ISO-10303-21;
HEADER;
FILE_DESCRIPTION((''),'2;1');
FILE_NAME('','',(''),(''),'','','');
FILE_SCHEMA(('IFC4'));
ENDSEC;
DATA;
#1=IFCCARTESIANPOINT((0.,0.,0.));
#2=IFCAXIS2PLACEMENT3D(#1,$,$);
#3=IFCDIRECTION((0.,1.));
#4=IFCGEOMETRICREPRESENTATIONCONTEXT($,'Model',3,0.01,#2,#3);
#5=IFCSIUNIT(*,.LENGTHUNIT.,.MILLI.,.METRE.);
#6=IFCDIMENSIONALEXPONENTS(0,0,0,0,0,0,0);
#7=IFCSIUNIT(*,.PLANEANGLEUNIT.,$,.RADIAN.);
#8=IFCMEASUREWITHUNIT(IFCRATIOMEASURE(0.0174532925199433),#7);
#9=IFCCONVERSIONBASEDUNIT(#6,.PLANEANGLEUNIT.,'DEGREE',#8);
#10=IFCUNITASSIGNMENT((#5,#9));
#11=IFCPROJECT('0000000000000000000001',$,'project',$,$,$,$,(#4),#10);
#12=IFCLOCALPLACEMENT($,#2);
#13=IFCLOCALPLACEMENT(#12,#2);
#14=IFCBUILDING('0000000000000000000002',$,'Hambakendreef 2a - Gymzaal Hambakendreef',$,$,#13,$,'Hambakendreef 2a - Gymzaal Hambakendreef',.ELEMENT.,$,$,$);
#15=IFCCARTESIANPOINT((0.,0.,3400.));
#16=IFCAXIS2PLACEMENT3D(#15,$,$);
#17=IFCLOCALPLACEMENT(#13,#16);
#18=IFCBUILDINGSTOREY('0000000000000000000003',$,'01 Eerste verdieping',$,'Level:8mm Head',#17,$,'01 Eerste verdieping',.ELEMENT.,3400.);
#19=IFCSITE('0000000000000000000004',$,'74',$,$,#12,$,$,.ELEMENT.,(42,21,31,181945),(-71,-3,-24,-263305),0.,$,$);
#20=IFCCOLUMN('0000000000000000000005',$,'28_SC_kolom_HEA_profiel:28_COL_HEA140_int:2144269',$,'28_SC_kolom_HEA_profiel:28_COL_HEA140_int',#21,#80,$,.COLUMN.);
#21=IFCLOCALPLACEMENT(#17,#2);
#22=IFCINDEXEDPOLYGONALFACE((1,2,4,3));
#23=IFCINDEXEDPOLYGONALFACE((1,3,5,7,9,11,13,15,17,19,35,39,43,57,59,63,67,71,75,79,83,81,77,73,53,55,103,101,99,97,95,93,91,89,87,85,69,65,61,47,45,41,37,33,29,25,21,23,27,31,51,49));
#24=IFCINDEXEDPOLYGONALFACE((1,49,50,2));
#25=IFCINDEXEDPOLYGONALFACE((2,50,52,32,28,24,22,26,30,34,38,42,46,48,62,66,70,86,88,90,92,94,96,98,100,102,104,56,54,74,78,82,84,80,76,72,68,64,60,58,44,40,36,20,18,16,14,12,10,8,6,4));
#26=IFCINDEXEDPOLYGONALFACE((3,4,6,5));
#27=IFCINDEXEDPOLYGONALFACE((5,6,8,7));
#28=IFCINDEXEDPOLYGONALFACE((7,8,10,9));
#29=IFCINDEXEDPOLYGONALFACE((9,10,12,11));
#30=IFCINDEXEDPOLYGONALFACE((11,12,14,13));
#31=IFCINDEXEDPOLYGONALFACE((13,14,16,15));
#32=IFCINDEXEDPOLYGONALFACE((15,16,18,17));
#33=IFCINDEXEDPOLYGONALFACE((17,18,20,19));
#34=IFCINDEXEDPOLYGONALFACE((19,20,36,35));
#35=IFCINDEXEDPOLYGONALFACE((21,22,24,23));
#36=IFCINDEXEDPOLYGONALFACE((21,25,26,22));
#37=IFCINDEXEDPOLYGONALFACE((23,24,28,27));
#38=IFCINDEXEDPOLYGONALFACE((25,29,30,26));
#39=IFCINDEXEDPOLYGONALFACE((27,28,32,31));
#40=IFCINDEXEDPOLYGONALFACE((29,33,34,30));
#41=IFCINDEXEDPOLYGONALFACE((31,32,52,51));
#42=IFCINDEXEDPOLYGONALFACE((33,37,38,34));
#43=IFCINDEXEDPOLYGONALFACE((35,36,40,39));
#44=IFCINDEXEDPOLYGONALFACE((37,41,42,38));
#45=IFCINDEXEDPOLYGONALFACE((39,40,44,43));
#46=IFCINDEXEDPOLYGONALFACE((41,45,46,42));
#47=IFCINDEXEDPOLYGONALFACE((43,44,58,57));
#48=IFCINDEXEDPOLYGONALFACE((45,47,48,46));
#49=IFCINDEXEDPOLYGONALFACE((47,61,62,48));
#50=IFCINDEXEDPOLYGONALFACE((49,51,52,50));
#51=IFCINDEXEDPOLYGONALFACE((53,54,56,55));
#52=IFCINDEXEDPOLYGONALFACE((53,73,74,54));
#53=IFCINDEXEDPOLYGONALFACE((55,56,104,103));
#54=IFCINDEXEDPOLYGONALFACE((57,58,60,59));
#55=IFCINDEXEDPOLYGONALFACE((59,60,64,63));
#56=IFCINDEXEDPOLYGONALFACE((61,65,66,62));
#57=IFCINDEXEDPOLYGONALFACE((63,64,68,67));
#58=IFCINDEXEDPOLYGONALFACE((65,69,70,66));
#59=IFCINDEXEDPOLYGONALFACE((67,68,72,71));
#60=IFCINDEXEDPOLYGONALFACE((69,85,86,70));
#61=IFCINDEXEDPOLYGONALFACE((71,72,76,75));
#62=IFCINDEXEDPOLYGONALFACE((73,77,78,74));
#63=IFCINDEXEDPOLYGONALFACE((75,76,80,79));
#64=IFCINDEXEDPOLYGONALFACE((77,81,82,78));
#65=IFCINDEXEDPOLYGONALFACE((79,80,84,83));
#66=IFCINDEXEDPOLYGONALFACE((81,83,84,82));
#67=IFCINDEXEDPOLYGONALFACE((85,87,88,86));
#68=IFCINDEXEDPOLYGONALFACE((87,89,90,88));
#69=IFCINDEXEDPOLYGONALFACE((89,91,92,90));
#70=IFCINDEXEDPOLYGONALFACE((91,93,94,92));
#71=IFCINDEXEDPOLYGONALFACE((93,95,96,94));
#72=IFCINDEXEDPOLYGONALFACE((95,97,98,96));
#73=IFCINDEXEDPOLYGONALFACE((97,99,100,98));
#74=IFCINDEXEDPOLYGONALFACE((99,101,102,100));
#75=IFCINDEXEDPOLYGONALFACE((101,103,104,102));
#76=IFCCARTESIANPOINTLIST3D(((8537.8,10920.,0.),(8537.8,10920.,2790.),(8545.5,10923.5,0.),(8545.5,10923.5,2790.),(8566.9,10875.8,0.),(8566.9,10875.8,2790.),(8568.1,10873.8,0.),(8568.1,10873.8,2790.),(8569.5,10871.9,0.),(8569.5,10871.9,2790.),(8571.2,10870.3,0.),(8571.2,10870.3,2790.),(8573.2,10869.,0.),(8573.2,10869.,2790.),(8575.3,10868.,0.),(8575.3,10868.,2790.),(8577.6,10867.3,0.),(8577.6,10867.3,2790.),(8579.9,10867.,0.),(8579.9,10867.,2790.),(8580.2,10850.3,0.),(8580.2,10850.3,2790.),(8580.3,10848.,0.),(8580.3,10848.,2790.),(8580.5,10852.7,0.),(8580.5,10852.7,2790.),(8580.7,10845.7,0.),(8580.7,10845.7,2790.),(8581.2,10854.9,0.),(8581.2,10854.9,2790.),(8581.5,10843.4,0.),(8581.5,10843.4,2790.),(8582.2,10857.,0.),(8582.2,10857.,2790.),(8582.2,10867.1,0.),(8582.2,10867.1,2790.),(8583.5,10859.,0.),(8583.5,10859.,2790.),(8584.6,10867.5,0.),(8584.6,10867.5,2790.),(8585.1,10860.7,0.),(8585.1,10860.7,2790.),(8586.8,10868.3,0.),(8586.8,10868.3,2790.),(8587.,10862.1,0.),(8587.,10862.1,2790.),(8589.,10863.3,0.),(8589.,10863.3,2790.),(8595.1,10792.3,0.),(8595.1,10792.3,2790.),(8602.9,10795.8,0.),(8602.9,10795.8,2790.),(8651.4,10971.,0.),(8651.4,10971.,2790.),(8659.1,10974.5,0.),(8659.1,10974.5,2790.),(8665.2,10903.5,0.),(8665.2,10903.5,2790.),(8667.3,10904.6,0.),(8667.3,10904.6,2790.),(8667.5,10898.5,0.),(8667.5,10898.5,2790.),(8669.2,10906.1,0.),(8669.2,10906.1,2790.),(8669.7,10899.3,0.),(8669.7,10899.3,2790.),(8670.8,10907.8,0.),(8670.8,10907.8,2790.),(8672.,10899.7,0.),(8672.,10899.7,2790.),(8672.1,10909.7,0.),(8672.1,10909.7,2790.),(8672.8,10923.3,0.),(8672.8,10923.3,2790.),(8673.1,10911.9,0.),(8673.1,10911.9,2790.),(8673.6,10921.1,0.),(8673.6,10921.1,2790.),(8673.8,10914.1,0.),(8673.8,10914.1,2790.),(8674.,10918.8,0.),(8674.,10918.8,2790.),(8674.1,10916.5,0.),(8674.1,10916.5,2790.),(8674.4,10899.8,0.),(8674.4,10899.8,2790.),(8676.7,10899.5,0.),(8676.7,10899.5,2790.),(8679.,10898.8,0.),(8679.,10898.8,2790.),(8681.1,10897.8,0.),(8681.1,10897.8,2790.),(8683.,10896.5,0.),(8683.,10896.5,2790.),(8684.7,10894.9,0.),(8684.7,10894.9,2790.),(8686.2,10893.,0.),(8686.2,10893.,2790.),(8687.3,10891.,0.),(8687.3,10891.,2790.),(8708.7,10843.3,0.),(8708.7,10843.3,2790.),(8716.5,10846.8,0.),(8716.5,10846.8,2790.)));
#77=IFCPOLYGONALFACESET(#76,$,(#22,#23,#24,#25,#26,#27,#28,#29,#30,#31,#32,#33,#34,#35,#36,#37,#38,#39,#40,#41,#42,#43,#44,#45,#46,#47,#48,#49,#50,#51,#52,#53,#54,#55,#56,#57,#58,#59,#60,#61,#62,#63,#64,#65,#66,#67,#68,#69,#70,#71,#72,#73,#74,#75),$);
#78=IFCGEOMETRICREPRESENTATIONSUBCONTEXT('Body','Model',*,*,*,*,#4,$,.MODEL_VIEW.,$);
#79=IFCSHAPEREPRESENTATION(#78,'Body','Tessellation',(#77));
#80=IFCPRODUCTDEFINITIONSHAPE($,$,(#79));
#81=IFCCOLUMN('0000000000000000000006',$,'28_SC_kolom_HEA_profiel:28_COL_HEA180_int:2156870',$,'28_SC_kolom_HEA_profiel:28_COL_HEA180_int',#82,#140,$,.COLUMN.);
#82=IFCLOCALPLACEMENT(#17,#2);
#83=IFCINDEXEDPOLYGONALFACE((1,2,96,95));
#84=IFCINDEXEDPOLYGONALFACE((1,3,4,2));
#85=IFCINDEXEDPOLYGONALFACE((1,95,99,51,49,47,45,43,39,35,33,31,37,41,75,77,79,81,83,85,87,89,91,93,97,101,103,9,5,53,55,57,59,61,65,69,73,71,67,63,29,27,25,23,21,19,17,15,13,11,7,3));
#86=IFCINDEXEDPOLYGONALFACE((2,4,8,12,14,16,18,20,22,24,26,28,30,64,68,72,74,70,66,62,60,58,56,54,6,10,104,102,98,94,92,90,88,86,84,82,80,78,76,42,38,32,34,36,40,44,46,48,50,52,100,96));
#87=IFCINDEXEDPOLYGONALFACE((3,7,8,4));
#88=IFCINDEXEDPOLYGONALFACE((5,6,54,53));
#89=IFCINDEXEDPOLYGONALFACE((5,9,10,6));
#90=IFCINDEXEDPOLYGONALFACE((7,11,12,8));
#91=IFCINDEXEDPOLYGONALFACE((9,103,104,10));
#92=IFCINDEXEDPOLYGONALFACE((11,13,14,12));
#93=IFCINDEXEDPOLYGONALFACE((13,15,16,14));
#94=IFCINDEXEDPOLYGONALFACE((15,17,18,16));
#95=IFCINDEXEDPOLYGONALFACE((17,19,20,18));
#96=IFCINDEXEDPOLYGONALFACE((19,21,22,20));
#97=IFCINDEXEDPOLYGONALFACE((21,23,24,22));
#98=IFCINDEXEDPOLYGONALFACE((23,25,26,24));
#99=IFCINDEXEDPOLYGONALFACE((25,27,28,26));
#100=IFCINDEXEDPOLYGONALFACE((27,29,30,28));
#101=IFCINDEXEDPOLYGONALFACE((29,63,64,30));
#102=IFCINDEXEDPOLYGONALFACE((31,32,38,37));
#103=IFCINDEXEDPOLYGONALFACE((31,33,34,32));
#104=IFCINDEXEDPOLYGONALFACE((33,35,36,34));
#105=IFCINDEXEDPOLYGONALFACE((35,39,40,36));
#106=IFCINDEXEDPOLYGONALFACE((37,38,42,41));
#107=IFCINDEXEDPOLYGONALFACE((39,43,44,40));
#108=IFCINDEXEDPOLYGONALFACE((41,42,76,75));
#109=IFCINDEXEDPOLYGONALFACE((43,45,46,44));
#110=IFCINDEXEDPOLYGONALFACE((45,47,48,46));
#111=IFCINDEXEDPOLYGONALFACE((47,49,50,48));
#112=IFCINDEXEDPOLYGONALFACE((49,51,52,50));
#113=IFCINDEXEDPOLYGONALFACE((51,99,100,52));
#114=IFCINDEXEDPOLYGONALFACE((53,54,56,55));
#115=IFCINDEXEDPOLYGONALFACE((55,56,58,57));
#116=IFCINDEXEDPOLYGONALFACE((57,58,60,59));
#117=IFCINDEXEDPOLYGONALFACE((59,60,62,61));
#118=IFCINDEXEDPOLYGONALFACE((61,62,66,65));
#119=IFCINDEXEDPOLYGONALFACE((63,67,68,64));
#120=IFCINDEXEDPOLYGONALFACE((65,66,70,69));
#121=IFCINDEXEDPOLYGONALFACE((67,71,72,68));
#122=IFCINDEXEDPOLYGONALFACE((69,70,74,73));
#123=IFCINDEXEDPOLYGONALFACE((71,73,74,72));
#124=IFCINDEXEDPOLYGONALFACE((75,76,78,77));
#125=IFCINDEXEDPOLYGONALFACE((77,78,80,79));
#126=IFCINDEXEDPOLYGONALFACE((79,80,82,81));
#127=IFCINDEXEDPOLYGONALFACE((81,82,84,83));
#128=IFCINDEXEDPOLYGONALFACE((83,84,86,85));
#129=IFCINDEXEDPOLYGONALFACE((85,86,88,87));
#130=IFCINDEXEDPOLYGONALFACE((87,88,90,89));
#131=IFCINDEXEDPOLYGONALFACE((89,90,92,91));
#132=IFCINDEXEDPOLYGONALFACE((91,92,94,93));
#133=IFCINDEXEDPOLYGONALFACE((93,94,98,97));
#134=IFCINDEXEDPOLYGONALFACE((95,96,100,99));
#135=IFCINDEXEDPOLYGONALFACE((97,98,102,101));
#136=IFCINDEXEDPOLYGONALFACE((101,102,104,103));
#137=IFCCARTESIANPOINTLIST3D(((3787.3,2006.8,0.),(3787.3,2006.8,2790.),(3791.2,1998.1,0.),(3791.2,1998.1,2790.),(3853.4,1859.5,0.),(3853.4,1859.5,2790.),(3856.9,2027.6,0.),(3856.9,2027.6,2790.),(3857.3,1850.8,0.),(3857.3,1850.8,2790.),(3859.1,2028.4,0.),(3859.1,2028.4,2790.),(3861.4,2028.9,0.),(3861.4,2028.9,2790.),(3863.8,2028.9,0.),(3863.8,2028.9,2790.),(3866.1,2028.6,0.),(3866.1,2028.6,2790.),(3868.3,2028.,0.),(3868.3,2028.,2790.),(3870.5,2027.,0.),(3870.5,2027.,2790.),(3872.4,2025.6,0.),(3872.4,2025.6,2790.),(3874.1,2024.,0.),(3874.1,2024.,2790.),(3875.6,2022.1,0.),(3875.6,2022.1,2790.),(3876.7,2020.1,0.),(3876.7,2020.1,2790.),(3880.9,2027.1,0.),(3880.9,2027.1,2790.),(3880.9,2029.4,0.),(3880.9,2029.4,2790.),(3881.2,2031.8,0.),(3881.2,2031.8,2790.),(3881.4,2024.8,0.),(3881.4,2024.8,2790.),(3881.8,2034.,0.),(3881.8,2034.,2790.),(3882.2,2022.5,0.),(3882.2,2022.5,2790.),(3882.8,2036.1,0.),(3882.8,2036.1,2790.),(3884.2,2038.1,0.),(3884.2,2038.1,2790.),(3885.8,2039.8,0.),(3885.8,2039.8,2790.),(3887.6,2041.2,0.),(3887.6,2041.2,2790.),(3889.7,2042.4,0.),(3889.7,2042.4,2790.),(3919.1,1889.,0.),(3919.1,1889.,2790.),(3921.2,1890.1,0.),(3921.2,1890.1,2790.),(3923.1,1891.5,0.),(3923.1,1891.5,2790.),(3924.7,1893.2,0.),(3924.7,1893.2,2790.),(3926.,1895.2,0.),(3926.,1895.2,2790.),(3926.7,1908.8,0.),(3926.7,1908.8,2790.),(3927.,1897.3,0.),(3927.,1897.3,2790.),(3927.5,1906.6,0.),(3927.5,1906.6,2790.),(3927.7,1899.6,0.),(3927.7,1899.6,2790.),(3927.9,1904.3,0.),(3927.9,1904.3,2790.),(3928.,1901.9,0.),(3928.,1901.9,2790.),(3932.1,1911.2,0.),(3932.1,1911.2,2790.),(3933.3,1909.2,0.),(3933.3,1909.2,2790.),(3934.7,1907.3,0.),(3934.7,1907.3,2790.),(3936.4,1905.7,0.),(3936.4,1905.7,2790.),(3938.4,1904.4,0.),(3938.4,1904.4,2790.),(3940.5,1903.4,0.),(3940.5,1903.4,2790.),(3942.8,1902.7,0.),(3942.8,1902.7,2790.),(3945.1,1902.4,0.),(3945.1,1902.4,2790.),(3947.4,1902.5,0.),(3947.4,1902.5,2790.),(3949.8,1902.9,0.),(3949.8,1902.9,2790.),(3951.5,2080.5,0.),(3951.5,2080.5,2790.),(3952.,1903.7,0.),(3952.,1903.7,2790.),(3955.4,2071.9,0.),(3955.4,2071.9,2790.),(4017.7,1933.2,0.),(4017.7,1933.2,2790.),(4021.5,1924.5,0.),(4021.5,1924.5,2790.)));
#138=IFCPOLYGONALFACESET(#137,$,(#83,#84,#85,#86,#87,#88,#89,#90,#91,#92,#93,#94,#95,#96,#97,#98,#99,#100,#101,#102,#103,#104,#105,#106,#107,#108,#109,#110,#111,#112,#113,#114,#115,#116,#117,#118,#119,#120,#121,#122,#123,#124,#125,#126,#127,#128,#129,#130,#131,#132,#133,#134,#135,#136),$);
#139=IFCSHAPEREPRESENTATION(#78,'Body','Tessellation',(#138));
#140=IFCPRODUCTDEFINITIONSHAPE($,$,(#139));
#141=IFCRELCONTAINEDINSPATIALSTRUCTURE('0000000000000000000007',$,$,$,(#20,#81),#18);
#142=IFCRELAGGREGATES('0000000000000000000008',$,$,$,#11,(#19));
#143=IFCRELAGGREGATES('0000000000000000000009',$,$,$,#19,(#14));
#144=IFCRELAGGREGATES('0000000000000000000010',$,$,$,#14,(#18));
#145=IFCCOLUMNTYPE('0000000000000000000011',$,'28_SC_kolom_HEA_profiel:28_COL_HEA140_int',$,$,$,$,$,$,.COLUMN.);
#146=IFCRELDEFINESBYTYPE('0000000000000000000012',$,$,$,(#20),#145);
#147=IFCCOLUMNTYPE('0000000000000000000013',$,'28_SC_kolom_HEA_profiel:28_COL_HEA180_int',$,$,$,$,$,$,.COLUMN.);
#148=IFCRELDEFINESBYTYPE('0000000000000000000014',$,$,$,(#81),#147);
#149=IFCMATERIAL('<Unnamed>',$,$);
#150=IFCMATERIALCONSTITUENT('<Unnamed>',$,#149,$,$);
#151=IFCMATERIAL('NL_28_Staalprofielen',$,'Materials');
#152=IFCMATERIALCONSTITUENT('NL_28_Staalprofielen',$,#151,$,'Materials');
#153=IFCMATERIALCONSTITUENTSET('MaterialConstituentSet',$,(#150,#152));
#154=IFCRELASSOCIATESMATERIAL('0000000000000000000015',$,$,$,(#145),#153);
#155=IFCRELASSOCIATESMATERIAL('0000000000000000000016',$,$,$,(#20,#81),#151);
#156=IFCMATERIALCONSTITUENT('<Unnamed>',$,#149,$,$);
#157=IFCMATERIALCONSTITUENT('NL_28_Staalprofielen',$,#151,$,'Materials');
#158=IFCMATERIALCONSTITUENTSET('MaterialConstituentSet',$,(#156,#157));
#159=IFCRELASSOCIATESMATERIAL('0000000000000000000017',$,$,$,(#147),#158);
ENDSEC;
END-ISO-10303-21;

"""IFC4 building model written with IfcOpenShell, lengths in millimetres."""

from ifc_helpers import new_model, entity, si_unit, converted_unit, direction, frame, origin, place, context, subcontext, project, spatial, indexed_curve, outline, extrude, source, transform, mapped, material, constituent, constituent_set, type_object, type_shapes, element, save


model = new_model("IFC4")

# Units and contexts
model_context = context("Model", 3, precision=0.01, world=origin(), true_north=direction((0.0, 1.0)))
body_context = subcontext(model_context, "Body", "Model", "MODEL_VIEW")
ifc_project = project(units=[si_unit("LENGTHUNIT", "METRE", prefix="MILLI"), converted_unit("PLANEANGLEUNIT", "DEGREE", entity("IfcRatioMeasure", 0.0174532925199433), si_unit("PLANEANGLEUNIT", "RADIAN"), dimensions=[0, 0, 0, 0, 0, 0, 0])], contexts=[model_context])

# Site, building, storey
site_placement = place(None, origin())
site = spatial("IfcSite", under=ifc_project, at=site_placement, Name="74", CompositionType="ELEMENT", RefLatitude=(42, 21, 31, 181945), RefLongitude=(-71, -3, -24, -263305), RefElevation=0.0)
building_placement = place(site_placement, origin())
building = spatial("IfcBuilding", under=site, at=building_placement, Name="Hambakendreef 2a - Gymzaal Hambakendreef", LongName="Hambakendreef 2a - Gymzaal Hambakendreef", CompositionType="ELEMENT")
storey_placement = place(building_placement, frame((0.0, 0.0, 3400.0)))
storey = spatial("IfcBuildingStorey", under=building, at=storey_placement, Name="01 Eerste verdieping", ObjectType="Level:8mm Head", LongName="01 Eerste verdieping", CompositionType="ELEMENT", Elevation=3400.0)

# Columns
ifc_material_1 = material(Name="NL_28_Staalprofielen", Category="Materials")
ifc_material_2 = material(Name="<Unnamed>")
ifc_constituent_1 = constituent(ifc_material_2, Name="<Unnamed>")
ifc_constituent_2 = constituent(ifc_material_1, Name="NL_28_Staalprofielen", Category="Materials")
ifc_constituent_set_1 = constituent_set(constituents=[ifc_constituent_1, ifc_constituent_2], Name="MaterialConstituentSet")
column_type_1 = type_object("IfcColumnType", Name="28_SC_kolom_HEA_profiel:28_COL_HEA140_int", PredefinedType="COLUMN", material=ifc_constituent_set_1)
shared_shape_1 = source(origin(), body_context, "Body", "SweptSolid", [
    extrude(outline(indexed_curve([(58.0, -70.0), (66.5, -70.0), (66.5, 70.0), (58.0, 70.0), (58.0, 17.8), (57.8, 15.4), (57.3, 13.1), (56.4, 10.9), (55.1, 8.9), (53.6, 7.1), (51.8, 5.6), (49.8, 4.4), (47.6, 3.5), (45.3, 2.9), (43.0, 2.8), (-43.0, 2.8), (-45.3, 2.9), (-47.6, 3.5), (-49.8, 4.4), (-51.8, 5.6), (-53.6, 7.1), (-55.1, 8.9), (-56.4, 10.9), (-57.3, 13.1), (-57.8, 15.4), (-58.0, 17.7), (-58.0, 70.0), (-66.5, 70.0), (-66.5, -70.0), (-58.0, -70.0), (-58.0, -17.8), (-57.8, -15.4), (-57.3, -13.1), (-56.4, -10.9), (-55.1, -8.9), (-53.6, -7.1), (-51.8, -5.6), (-49.8, -4.4), (-47.6, -3.5), (-45.3, -2.9), (-43.0, -2.7), (43.0, -2.8), (45.3, -2.9), (47.6, -3.5), (49.8, -4.4), (51.8, -5.6), (53.6, -7.1), (55.1, -8.9), (56.4, -10.9), (57.3, -13.1), (57.8, -15.4), (58.0, -17.8), (58.0, -70.0)], self_intersect=False)), frame((0.0, 0.0, 3400.0), z_axis=(0.0, 0.0, 1.0), x_axis=(0.0, -1.0, 0.0)), (0.0, 0.0, 1.0), 2790.0),
])
type_shapes(column_type_1, [shared_shape_1])
column_1_placement = place(storey_placement, frame((8627.1, 10883.4, -3400.0), z_axis=(0.0, 0.0, 1.0), x_axis=(0.40959, -0.91227, 0.0)))
element("IfcColumn", 1, at=column_1_placement, inside=storey, type_object=column_type_1, material=ifc_material_1, Name="28_SC_kolom_HEA_profiel:28_COL_HEA140_int:2144269", ObjectType="28_SC_kolom_HEA_profiel:28_COL_HEA140_int", PredefinedType="COLUMN", context=body_context, shape_type="MappedRepresentation", body=[
    mapped(shared_shape_1, transform((0.0, 0.0, 0.0), scale=1.0)),
])
ifc_constituent_3 = constituent(ifc_material_2, Name="<Unnamed>")
ifc_constituent_4 = constituent(ifc_material_1, Name="NL_28_Staalprofielen", Category="Materials")
ifc_constituent_set_2 = constituent_set(constituents=[ifc_constituent_3, ifc_constituent_4], Name="MaterialConstituentSet")
column_type_2 = type_object("IfcColumnType", Name="28_SC_kolom_HEA_profiel:28_COL_HEA180_int", PredefinedType="COLUMN", material=ifc_constituent_set_2)
shared_shape_2 = source(origin(), body_context, "Body", "SweptSolid", [
    extrude(outline(indexed_curve([(76.0, -90.0), (85.5, -90.0), (85.5, 90.0), (76.0, 90.0), (76.0, 18.0), (75.8, 15.7), (75.3, 13.4), (74.4, 11.2), (73.1, 9.2), (71.6, 7.4), (69.8, 5.9), (67.8, 4.6), (65.6, 3.7), (63.3, 3.2), (61.0, 3.0), (-61.0, 3.0), (-63.3, 3.2), (-65.6, 3.7), (-67.8, 4.6), (-69.8, 5.9), (-71.6, 7.4), (-73.1, 9.2), (-74.4, 11.2), (-75.3, 13.4), (-75.8, 15.7), (-76.0, 18.0), (-76.0, 90.0), (-85.5, 90.0), (-85.5, -90.0), (-76.0, -90.0), (-76.0, -18.0), (-75.8, -15.7), (-75.3, -13.4), (-74.4, -11.2), (-73.1, -9.2), (-71.6, -7.4), (-69.8, -5.9), (-67.8, -4.6), (-65.6, -3.7), (-63.3, -3.2), (-61.0, -3.0), (61.0, -3.0), (63.3, -3.2), (65.6, -3.7), (67.8, -4.6), (69.8, -5.9), (71.6, -7.4), (73.1, -9.2), (74.4, -11.2), (75.3, -13.4), (75.8, -15.7), (76.0, -18.0), (76.0, -90.0)], self_intersect=False)), frame((0.0, 0.0, 3400.0), z_axis=(0.0, 0.0, 1.0), x_axis=(0.0, -1.0, 0.0)), (0.0, 0.0, 1.0), 2790.0),
])
type_shapes(column_type_2, [shared_shape_2])
for number, where, z_axis, x_axis, name in (
    (2, (3904.4, 1965.7, -3400.0), (0.0, 0.0, 1.0), (0.91227, 0.40959, 0.0), "28_SC_kolom_HEA_profiel:28_COL_HEA180_int:2156870"),
):
    element("IfcColumn", number, at=place(storey_placement, frame(where, z_axis=z_axis, x_axis=x_axis)), inside=storey, type_object=column_type_2, material=ifc_material_1, Name=name, ObjectType="28_SC_kolom_HEA_profiel:28_COL_HEA180_int", PredefinedType="COLUMN", context=body_context, shape_type="MappedRepresentation", body=[
        mapped(shared_shape_2, transform((0.0, 0.0, 0.0), scale=1.0)),
    ])

save(model, "model.ifc")
